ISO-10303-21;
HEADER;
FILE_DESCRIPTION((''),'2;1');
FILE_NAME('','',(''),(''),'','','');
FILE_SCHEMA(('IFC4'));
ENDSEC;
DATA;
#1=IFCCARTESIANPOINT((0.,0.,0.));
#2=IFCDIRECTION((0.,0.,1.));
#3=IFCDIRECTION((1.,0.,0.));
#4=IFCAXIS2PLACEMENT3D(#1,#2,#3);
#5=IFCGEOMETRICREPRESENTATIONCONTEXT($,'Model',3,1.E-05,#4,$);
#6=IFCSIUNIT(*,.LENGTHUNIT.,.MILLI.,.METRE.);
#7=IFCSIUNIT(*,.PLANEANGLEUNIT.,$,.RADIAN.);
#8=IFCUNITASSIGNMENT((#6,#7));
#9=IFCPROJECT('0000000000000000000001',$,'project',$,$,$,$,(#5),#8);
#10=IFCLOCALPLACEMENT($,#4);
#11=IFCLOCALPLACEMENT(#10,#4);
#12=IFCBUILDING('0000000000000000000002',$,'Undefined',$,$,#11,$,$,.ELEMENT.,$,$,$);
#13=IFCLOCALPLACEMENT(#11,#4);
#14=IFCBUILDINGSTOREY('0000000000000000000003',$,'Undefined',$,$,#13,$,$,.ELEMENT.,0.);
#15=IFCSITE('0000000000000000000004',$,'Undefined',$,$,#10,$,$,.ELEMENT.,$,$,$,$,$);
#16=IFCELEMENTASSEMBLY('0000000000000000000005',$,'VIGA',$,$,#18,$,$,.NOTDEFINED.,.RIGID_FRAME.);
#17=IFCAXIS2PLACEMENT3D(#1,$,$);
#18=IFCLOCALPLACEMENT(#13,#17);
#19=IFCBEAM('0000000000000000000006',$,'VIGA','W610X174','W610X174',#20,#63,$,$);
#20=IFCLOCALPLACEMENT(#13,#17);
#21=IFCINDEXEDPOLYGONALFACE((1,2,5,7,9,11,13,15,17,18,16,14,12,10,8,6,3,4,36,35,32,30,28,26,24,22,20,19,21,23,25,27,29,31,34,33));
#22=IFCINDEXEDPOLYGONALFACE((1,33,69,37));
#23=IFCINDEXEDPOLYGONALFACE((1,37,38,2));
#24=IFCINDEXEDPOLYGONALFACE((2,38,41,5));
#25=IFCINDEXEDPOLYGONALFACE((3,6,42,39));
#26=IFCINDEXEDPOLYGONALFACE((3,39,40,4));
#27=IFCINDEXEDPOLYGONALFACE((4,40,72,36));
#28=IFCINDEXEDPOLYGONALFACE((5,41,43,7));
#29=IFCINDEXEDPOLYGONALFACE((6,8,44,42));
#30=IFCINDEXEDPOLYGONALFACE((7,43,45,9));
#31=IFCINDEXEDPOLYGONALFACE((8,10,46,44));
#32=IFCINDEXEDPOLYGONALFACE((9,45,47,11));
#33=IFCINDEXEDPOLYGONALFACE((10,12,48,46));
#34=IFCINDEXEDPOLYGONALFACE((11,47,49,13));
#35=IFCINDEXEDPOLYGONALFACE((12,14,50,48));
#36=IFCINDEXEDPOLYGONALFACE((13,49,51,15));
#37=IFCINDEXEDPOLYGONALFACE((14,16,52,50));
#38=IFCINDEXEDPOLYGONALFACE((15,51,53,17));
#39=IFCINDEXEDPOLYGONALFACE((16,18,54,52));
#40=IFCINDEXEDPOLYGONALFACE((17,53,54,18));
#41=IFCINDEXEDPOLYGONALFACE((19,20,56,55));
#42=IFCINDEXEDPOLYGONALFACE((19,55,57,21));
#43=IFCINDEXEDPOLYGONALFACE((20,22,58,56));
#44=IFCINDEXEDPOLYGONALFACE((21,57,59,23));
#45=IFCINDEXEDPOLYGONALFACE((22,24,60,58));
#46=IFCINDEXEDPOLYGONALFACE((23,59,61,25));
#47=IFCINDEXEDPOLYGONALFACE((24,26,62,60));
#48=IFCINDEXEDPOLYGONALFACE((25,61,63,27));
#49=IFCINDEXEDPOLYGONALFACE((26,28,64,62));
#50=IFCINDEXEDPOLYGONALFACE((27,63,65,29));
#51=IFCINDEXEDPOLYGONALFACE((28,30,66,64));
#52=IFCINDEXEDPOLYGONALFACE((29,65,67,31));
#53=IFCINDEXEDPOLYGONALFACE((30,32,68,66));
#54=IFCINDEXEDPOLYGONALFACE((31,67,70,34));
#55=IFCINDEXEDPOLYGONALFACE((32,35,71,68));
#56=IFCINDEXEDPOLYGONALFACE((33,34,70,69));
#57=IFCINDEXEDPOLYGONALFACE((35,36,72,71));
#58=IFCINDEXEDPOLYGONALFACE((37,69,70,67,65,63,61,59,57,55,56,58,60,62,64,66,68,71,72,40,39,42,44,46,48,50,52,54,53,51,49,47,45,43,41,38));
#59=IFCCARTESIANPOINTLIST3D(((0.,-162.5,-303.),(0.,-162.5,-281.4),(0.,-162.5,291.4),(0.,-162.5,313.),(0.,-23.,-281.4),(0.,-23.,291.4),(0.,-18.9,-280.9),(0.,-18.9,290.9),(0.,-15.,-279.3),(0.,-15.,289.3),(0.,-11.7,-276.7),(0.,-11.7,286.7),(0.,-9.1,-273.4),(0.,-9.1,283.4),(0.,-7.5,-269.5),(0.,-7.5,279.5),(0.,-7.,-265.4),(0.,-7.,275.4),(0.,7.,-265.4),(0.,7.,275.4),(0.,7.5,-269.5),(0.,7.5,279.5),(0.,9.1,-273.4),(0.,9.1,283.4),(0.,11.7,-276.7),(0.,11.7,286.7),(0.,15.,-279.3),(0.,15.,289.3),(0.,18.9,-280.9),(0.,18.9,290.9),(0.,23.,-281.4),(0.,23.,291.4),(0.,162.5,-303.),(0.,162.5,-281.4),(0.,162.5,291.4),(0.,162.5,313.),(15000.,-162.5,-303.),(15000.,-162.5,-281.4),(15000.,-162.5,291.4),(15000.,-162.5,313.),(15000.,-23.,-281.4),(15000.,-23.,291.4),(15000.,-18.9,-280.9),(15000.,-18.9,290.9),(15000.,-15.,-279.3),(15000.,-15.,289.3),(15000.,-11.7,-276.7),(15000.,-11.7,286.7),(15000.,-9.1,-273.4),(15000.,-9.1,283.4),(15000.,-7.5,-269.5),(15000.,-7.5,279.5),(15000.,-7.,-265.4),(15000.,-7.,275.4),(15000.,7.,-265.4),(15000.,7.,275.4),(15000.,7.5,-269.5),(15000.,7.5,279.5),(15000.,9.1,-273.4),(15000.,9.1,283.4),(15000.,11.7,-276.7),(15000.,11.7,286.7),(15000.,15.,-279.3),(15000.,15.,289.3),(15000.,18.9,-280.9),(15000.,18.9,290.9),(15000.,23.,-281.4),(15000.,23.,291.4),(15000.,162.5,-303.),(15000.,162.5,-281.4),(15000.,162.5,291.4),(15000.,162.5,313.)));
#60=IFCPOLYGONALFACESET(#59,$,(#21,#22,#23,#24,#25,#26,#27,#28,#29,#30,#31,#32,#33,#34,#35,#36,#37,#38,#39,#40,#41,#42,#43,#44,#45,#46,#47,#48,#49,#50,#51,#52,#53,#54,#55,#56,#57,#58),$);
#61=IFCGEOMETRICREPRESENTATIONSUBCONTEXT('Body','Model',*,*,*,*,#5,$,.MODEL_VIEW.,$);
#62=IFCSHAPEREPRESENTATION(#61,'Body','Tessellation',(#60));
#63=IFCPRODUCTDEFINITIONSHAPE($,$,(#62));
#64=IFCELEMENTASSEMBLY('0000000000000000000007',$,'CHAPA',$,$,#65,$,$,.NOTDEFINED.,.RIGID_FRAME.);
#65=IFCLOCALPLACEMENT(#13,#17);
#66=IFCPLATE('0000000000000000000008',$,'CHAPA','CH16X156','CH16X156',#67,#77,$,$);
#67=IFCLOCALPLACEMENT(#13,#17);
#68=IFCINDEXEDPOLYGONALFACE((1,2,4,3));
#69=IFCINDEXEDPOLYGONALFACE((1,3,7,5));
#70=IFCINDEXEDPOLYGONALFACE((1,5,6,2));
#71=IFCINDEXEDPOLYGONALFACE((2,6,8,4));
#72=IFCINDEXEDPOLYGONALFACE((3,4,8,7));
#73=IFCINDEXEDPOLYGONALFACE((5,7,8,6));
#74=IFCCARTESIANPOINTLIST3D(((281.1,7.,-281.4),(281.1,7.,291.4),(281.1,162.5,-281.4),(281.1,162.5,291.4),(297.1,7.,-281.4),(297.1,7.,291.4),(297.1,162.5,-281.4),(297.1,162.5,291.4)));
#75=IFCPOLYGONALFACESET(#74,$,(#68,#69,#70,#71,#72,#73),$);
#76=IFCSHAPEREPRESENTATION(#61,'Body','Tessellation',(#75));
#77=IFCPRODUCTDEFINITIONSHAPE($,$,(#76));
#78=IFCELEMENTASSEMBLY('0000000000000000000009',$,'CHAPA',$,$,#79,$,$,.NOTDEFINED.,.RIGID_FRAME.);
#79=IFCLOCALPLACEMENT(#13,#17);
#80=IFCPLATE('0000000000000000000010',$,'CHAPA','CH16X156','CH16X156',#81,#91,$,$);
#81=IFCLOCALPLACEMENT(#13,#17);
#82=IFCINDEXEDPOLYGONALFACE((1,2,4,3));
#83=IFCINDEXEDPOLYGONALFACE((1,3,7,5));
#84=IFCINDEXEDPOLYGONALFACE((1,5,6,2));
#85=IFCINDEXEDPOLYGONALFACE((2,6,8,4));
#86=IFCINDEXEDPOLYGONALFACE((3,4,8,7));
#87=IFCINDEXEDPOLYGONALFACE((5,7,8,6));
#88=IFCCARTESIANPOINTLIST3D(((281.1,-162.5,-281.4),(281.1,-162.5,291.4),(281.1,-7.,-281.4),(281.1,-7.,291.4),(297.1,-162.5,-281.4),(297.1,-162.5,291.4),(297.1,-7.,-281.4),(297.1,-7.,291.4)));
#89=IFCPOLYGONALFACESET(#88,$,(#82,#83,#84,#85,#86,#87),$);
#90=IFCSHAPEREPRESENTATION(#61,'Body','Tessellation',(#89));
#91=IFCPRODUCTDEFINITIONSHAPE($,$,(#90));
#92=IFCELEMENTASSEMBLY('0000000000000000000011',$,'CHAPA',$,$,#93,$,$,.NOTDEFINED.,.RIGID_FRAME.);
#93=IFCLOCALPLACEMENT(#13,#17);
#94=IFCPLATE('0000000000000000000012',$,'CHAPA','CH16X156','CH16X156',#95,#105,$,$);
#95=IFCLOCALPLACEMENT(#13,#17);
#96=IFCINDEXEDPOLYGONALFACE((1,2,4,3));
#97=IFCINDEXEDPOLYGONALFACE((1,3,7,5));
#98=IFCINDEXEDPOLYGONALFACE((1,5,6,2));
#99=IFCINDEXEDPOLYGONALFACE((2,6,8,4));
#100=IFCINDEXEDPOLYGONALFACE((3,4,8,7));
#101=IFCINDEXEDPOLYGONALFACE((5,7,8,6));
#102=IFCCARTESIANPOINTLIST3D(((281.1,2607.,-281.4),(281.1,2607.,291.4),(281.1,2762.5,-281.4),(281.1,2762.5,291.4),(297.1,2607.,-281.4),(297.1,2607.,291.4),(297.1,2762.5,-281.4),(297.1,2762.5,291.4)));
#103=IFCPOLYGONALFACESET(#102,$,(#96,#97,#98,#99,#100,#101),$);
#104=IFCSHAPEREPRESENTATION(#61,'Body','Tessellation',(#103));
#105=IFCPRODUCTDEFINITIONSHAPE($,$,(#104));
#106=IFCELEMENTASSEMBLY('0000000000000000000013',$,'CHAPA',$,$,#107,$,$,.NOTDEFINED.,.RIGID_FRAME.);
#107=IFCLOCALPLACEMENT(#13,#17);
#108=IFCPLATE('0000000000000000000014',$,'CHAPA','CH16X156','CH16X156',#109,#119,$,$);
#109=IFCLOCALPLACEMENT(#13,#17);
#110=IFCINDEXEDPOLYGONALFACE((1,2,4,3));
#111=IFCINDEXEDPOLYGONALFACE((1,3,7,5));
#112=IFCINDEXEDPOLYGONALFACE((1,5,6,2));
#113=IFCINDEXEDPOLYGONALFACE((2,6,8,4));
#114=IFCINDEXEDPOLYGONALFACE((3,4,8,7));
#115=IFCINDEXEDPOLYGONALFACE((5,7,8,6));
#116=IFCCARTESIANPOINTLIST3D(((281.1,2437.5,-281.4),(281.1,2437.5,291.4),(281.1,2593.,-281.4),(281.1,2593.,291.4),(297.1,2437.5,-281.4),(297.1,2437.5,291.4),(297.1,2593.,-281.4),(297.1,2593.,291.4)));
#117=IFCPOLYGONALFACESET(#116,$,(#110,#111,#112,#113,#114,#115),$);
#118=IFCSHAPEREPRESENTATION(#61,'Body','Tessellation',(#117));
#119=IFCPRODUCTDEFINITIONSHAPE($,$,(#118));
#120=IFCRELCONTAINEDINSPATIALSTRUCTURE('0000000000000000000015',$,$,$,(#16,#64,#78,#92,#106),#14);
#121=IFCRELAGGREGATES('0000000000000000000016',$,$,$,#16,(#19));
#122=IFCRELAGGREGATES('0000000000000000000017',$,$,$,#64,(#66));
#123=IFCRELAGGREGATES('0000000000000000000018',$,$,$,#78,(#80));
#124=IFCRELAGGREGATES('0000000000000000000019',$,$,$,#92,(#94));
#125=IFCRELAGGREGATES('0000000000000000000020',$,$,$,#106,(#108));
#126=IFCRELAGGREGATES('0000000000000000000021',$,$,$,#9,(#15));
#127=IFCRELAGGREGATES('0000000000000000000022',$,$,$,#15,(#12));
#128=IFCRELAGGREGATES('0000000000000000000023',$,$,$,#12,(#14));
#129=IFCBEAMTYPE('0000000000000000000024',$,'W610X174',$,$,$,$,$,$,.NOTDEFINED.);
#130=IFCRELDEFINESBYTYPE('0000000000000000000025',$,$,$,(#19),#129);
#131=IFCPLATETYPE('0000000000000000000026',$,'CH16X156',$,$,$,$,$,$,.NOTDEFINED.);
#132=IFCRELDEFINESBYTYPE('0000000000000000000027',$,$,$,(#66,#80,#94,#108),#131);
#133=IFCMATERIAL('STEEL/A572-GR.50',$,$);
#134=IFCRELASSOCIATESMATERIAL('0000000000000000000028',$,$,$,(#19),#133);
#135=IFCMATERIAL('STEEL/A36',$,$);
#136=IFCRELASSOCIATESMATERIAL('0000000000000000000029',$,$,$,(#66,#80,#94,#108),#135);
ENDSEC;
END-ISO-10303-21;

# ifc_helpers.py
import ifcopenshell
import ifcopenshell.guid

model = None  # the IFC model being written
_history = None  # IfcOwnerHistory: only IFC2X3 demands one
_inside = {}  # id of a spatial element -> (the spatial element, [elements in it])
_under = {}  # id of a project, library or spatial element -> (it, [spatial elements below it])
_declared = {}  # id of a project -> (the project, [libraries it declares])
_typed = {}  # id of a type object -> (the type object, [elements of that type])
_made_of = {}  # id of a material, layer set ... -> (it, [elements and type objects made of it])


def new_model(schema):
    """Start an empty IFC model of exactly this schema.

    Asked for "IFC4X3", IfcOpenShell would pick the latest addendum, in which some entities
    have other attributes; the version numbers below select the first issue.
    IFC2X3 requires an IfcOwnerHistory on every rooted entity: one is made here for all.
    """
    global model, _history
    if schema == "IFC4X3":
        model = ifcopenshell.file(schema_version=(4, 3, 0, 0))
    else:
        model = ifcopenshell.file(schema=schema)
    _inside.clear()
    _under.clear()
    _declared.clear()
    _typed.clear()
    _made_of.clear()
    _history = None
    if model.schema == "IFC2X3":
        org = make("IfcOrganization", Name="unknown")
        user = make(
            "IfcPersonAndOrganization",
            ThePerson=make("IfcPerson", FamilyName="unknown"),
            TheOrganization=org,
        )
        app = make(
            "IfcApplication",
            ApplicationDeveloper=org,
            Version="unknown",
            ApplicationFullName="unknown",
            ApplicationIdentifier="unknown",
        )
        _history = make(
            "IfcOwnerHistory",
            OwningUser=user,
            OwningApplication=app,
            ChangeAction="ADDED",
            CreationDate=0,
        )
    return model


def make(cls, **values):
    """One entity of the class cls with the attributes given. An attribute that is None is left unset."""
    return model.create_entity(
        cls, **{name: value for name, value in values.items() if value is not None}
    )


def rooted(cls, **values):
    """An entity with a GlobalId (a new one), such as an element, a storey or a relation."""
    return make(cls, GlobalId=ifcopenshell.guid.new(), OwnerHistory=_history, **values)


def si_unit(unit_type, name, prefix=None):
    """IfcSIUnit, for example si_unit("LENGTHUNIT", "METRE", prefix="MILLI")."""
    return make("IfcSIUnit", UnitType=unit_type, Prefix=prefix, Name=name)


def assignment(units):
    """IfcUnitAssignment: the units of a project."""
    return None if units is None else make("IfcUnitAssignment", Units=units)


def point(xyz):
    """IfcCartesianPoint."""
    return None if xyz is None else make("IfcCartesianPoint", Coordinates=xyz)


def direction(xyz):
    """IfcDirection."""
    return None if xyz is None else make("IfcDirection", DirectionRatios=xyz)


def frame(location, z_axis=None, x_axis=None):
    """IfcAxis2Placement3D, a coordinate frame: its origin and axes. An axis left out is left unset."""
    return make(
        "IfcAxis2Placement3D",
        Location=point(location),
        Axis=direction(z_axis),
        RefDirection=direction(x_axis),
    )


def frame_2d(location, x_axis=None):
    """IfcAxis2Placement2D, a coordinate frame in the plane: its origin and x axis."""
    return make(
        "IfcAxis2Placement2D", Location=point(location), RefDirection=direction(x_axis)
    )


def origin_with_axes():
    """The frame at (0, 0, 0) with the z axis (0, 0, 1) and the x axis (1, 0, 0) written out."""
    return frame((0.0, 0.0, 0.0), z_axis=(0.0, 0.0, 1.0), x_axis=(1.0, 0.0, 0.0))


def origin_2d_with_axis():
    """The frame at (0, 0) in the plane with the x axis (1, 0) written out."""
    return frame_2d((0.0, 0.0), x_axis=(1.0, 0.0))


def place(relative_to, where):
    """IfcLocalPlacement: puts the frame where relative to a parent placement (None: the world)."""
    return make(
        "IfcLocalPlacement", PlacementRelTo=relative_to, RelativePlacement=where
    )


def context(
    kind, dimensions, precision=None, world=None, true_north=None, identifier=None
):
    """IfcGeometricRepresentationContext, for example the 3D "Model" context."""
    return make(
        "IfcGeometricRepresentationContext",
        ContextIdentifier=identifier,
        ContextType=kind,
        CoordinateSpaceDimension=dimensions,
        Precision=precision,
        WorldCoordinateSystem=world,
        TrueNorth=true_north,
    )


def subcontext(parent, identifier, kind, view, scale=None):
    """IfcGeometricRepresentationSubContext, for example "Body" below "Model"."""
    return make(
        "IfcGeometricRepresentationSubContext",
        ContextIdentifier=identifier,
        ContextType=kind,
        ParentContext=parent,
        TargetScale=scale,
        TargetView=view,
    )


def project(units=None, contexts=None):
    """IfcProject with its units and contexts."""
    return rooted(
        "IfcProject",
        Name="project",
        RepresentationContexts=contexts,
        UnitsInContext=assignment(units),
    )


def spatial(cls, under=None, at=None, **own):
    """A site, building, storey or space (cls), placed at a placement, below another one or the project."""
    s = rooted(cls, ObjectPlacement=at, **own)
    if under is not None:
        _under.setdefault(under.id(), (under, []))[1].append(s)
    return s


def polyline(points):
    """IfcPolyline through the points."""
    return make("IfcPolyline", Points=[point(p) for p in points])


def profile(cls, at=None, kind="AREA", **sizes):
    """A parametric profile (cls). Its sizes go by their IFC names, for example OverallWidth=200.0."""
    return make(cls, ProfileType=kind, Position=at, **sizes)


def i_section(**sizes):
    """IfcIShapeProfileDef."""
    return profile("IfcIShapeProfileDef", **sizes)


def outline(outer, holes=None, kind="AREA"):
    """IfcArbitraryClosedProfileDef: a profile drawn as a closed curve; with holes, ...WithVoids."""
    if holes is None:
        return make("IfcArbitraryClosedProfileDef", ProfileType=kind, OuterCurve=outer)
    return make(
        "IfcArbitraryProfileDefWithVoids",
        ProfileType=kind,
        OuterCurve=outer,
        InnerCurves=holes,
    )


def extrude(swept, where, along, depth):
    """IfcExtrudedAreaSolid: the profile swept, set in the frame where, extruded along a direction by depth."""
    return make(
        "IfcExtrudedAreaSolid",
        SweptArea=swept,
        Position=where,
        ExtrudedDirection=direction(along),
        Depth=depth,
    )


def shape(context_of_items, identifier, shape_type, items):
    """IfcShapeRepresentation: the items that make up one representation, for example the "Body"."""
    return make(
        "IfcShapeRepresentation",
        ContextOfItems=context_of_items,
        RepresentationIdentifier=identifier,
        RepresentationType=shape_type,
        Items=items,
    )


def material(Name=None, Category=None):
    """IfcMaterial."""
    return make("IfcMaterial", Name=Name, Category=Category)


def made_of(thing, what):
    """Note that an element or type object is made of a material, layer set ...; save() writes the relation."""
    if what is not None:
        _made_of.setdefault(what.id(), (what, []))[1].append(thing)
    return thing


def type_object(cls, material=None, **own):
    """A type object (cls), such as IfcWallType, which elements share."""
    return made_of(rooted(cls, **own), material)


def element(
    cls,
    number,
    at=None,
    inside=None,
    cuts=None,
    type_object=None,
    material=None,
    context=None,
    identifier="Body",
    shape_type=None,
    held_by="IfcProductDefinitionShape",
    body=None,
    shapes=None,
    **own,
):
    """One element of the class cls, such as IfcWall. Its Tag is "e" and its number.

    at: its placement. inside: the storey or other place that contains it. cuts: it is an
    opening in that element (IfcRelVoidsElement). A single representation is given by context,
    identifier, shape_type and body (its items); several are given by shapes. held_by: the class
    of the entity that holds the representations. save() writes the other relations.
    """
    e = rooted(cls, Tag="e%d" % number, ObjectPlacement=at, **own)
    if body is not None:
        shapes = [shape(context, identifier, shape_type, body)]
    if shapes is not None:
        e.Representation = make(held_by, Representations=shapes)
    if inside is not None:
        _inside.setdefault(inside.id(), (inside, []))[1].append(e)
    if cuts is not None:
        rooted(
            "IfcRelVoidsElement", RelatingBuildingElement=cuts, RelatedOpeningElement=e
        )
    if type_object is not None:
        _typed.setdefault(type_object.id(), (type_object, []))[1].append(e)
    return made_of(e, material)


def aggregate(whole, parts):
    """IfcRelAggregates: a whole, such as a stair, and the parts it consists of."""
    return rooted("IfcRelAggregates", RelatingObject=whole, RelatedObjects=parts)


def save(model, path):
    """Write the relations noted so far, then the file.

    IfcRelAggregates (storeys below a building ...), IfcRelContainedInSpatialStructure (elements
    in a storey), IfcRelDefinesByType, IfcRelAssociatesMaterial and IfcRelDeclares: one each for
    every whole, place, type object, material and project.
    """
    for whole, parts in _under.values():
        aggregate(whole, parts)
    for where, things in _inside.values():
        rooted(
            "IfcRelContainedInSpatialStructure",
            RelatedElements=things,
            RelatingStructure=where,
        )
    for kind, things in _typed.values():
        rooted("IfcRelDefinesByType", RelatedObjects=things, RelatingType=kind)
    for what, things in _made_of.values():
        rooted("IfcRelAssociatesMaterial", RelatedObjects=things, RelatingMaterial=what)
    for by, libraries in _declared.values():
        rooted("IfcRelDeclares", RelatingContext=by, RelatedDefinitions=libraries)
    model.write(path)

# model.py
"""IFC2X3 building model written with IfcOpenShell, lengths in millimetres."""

from ifc_helpers import new_model, si_unit, frame, origin_with_axes, origin_2d_with_axis, place, context, subcontext, project, spatial, polyline, i_section, outline, extrude, material, type_object, element, aggregate, save


model = new_model("IFC2X3")

# Units and contexts
model_context = context("Model", 3, precision=1e-05, world=origin_with_axes())
body_context = subcontext(model_context, "Body", "Model", "MODEL_VIEW")
ifc_project = project(units=[si_unit("LENGTHUNIT", "METRE", prefix="MILLI"), si_unit("PLANEANGLEUNIT", "RADIAN")], contexts=[model_context])

# Site, building, storey
site_placement = place(None, origin_with_axes())
site = spatial("IfcSite", under=ifc_project, at=site_placement, Name="Undefined", CompositionType="ELEMENT")
building_placement = place(site_placement, origin_with_axes())
building = spatial("IfcBuilding", under=site, at=building_placement, Name="Undefined", CompositionType="ELEMENT")
storey_placement = place(building_placement, origin_with_axes())
storey = spatial("IfcBuildingStorey", under=building, at=storey_placement, Name="Undefined", CompositionType="ELEMENT", Elevation=0.0)

# Element assembly, beam
ifc_material_1 = material(Name="STEEL/A572-GR.50")
beam_type_1 = type_object("IfcBeamType", Name="W610X174", PredefinedType="NOTDEFINED")
assembly_1_placement = place(storey_placement, origin_with_axes())
assembly_1 = element("IfcElementAssembly", 1, at=assembly_1_placement, inside=storey, Name="VIGA", AssemblyPlace="NOTDEFINED", PredefinedType="RIGID_FRAME")
beam_1_placement = place(assembly_1_placement, frame((0.0, 0.0, 5.0), z_axis=(0.0, 0.0, 1.0), x_axis=(1.0, 0.0, 0.0)))
beam_1 = element("IfcBeam", 2, at=beam_1_placement, type_object=beam_type_1, material=ifc_material_1, Name="VIGA", Description="W610X174", ObjectType="W610X174", context=body_context, shape_type="SweptSolid", body=[
    extrude(i_section(OverallWidth=325.0, OverallDepth=616.0, WebThickness=14.0, FlangeThickness=21.6, FilletRadius=16.0, at=origin_2d_with_axis()), frame((15000.0, 0.0, 0.0), z_axis=(-1.0, 0.0, 0.0), x_axis=(0.0, -1.0, 0.0)), (0.0, 0.0, 1.0), 15000.0),
])
aggregate(assembly_1, [beam_1])

# Element assemblies, plates
assembly_2_placement = place(storey_placement, origin_with_axes())
assembly_2 = element("IfcElementAssembly", 3, at=assembly_2_placement, inside=storey, Name="CHAPA", AssemblyPlace="NOTDEFINED", PredefinedType="RIGID_FRAME")
ifc_material_2 = material(Name="STEEL/A36")
plate_type = type_object("IfcPlateType", Name="CH16X156", PredefinedType="NOTDEFINED")
plate_1_placement = place(assembly_2_placement, frame((289.1, 162.5, 291.4), z_axis=(1.0, 0.0, 0.0), x_axis=(0.0, -1.0, 0.0)))
plate_1 = element("IfcPlate", 4, at=plate_1_placement, type_object=plate_type, material=ifc_material_2, Name="CHAPA", Description="CH16X156", ObjectType="CH16X156", context=body_context, shape_type="SweptSolid", body=[
    extrude(outline(polyline([(0.0, 0.0), (155.5, 0.0), (155.5, 572.8), (0.0, 572.8), (0.0, 0.0)])), frame((0.0, 0.0, -8.0), z_axis=(0.0, 0.0, 1.0), x_axis=(1.0, 0.0, 0.0)), (0.0, 0.0, 1.0), 16.0),
])
aggregate(assembly_2, [plate_1])
assembly_3_placement = place(storey_placement, origin_with_axes())
assembly_3 = element("IfcElementAssembly", 5, at=assembly_3_placement, inside=storey, Name="CHAPA", AssemblyPlace="NOTDEFINED", PredefinedType="RIGID_FRAME")
plate_2_placement = place(assembly_3_placement, frame((289.1, -7.0, 291.4), z_axis=(1.0, 0.0, 0.0), x_axis=(0.0, -1.0, 0.0)))
plate_2 = element("IfcPlate", 6, at=plate_2_placement, type_object=plate_type, material=ifc_material_2, Name="CHAPA", Description="CH16X156", ObjectType="CH16X156", context=body_context, shape_type="SweptSolid", body=[
    extrude(outline(polyline([(0.0, 0.0), (155.5, 0.0), (155.5, 572.8), (0.0, 572.8), (0.0, 0.0)])), frame((0.0, 0.0, -8.0), z_axis=(0.0, 0.0, 1.0), x_axis=(1.0, 0.0, 0.0)), (0.0, 0.0, 1.0), 16.0),
])
aggregate(assembly_3, [plate_2])
assembly_4_placement = place(storey_placement, origin_with_axes())
assembly_4 = element("IfcElementAssembly", 7, at=assembly_4_placement, inside=storey, Name="CHAPA", AssemblyPlace="NOTDEFINED", PredefinedType="RIGID_FRAME")
plate_3_placement = place(assembly_4_placement, frame((289.1, 2762.5, 291.4), z_axis=(1.0, 0.0, 0.0), x_axis=(0.0, -1.0, 0.0)))
plate_3 = element("IfcPlate", 8, at=plate_3_placement, type_object=plate_type, material=ifc_material_2, Name="CHAPA", Description="CH16X156", ObjectType="CH16X156", context=body_context, shape_type="SweptSolid", body=[
    extrude(outline(polyline([(0.0, 0.0), (155.5, 0.0), (155.5, 572.8), (0.0, 572.8), (0.0, 0.0)])), frame((0.0, 0.0, -8.0), z_axis=(0.0, 0.0, 1.0), x_axis=(1.0, 0.0, 0.0)), (0.0, 0.0, 1.0), 16.0),
])
aggregate(assembly_4, [plate_3])
assembly_5_placement = place(storey_placement, origin_with_axes())
assembly_5 = element("IfcElementAssembly", 9, at=assembly_5_placement, inside=storey, Name="CHAPA", AssemblyPlace="NOTDEFINED", PredefinedType="RIGID_FRAME")
plate_4_placement = place(assembly_5_placement, frame((289.1, 2593.0, 291.4), z_axis=(1.0, 0.0, 0.0), x_axis=(0.0, -1.0, 0.0)))
plate_4 = element("IfcPlate", 10, at=plate_4_placement, type_object=plate_type, material=ifc_material_2, Name="CHAPA", Description="CH16X156", ObjectType="CH16X156", context=body_context, shape_type="SweptSolid", body=[
    extrude(outline(polyline([(0.0, 0.0), (155.5, 0.0), (155.5, 572.8), (0.0, 572.8), (0.0, 0.0)])), frame((0.0, 0.0, -8.0), z_axis=(0.0, 0.0, 1.0), x_axis=(1.0, 0.0, 0.0)), (0.0, 0.0, 1.0), 16.0),
])
aggregate(assembly_5, [plate_4])

save(model, "model.ifc")
